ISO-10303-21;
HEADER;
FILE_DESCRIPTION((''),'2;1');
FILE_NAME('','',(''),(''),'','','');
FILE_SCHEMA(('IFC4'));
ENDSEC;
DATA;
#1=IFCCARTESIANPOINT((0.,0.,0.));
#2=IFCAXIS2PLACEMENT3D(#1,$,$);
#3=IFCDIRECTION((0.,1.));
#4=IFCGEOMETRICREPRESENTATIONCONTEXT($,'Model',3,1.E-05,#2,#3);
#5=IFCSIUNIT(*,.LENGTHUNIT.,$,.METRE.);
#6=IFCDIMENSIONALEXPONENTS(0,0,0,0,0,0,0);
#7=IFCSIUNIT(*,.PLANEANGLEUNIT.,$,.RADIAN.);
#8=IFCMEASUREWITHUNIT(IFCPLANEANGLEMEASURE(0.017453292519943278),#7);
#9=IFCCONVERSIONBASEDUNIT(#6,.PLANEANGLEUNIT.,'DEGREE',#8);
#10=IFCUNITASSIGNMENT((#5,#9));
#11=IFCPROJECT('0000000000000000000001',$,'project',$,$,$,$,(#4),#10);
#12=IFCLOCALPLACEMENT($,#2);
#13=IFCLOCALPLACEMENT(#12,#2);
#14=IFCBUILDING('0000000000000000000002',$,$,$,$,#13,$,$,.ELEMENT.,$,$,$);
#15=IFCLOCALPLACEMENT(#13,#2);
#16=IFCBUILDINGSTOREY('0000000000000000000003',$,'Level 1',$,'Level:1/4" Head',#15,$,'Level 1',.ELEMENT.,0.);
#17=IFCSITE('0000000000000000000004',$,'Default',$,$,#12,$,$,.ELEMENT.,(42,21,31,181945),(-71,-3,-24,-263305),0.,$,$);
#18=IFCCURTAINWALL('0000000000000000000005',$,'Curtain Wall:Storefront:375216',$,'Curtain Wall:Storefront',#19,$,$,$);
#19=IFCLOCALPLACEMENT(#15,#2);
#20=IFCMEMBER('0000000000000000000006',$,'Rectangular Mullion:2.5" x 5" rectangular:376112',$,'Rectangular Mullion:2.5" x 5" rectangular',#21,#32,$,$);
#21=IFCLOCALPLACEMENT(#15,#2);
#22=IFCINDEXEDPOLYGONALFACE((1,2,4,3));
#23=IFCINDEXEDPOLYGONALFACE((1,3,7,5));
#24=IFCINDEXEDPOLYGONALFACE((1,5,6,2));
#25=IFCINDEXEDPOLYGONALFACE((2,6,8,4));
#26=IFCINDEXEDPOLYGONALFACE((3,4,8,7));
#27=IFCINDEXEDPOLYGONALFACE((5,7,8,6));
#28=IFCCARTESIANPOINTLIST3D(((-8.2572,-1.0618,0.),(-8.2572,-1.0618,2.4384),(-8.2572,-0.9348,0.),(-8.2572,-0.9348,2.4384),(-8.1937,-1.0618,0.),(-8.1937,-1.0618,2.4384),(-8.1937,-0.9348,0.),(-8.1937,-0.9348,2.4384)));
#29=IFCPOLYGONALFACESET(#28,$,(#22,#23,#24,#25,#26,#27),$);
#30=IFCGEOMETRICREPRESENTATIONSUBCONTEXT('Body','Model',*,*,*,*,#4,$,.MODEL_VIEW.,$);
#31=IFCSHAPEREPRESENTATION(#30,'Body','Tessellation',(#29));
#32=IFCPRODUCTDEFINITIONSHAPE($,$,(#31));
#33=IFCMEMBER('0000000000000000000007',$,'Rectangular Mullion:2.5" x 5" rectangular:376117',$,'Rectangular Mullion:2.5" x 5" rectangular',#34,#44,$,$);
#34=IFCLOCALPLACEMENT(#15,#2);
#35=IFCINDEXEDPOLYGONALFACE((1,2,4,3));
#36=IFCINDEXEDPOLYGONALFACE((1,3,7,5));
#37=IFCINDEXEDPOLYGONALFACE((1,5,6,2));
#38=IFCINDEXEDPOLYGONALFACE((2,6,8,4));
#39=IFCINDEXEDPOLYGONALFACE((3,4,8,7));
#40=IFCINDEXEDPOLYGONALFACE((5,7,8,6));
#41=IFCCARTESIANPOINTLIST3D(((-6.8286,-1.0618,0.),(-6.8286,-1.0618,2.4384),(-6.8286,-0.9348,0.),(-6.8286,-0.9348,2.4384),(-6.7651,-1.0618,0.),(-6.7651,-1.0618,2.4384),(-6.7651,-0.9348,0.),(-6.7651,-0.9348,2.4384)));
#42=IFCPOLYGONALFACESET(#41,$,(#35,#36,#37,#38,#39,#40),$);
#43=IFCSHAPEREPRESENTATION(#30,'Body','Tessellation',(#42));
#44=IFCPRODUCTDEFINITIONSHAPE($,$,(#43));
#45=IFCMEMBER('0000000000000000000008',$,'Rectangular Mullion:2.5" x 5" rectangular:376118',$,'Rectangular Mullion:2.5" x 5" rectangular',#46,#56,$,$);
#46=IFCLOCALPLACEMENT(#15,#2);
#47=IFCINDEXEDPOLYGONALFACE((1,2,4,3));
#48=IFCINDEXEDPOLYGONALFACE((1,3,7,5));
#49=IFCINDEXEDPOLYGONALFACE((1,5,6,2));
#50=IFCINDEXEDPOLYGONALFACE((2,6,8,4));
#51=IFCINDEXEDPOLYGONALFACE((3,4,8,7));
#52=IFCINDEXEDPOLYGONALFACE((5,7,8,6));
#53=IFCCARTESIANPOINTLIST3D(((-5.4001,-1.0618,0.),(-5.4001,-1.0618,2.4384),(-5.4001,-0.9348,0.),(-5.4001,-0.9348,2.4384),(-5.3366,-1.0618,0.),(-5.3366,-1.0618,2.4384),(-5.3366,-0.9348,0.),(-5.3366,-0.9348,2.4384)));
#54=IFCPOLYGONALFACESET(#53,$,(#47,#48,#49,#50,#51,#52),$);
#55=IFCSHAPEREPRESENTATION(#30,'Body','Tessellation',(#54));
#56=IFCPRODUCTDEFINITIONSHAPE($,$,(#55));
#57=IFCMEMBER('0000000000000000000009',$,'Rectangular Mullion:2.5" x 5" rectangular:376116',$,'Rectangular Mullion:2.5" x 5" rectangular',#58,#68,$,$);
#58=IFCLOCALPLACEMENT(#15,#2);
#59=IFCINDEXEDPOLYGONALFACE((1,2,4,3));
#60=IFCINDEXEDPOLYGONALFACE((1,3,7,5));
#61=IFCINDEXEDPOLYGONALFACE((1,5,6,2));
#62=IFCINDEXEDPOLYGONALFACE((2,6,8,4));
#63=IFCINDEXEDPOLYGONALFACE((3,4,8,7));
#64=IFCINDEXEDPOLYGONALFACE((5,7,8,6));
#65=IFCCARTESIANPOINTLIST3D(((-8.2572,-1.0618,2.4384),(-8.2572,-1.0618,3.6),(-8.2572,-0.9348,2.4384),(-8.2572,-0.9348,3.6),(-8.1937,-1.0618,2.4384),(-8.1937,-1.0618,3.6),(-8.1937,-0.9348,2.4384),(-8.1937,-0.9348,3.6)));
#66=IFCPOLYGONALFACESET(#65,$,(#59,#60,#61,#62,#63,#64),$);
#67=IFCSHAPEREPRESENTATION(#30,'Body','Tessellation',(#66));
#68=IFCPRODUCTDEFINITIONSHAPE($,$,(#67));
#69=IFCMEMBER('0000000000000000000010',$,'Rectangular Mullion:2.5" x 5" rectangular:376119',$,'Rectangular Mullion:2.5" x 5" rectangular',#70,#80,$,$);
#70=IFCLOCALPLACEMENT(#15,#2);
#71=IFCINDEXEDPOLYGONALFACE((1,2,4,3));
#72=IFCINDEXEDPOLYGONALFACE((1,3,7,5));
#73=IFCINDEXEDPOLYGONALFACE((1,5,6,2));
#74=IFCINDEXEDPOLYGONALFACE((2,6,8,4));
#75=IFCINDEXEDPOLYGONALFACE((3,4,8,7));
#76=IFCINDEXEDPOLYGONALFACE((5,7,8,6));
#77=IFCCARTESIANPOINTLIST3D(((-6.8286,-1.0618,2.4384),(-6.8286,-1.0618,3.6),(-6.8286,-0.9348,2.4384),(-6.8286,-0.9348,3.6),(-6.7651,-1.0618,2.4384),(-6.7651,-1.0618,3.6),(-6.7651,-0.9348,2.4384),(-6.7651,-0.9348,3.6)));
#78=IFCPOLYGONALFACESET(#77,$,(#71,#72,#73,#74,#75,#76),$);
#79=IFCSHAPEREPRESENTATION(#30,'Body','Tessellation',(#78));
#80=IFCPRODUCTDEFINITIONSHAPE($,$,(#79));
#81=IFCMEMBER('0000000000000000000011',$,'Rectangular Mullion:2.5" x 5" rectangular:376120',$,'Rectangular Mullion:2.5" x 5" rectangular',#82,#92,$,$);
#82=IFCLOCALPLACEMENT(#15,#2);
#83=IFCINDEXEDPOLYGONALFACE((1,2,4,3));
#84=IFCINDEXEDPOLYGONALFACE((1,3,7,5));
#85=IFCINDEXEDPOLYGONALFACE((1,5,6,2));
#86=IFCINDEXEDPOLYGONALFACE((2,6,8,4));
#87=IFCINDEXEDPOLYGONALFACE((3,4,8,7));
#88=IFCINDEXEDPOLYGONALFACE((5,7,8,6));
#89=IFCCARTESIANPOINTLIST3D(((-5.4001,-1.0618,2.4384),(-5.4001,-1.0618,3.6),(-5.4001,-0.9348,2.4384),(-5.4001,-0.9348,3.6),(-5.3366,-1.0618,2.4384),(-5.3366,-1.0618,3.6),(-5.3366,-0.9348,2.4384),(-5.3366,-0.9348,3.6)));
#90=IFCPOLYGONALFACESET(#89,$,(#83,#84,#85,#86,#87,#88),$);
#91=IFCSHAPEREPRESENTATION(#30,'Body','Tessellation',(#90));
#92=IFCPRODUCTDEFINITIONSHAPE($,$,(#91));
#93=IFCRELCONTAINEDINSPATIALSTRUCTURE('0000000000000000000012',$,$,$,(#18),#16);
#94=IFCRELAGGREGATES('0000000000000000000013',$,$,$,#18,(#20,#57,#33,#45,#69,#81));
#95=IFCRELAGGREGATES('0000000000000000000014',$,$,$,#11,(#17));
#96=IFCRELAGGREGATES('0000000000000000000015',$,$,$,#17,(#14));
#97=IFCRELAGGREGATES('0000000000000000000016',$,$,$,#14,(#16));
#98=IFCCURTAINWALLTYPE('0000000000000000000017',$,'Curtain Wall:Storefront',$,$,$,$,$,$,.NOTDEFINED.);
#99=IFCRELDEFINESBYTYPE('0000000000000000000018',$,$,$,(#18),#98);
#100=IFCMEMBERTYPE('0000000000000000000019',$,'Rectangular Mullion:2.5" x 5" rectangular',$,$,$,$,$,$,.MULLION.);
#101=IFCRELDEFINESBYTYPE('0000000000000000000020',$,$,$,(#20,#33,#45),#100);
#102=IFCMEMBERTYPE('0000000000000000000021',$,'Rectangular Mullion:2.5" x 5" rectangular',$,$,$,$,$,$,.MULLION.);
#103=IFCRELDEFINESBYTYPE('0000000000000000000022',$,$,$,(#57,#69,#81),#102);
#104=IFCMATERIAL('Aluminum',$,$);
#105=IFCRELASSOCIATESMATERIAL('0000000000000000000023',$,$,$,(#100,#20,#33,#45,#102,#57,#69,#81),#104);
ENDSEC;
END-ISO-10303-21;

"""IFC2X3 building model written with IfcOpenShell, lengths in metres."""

from ifc_helpers import new_model, entity, si_unit, converted_unit, direction, frame, origin, origin_2d_with_axis, place, context, subcontext, project, spatial, rectangle, extrude, source, transform, mapped, material, type_object, type_shapes, element, aggregate, save


model = new_model("IFC2X3")

# Units and contexts
model_context = context("Model", 3, precision=1e-05, world=origin(), true_north=direction((0.0, 1.0)))
body_context = subcontext(model_context, "Body", "Model", "MODEL_VIEW")
ifc_project = project(units=[si_unit("LENGTHUNIT", "METRE"), converted_unit("PLANEANGLEUNIT", "DEGREE", entity("IfcPlaneAngleMeasure", 0.017453292519943278), si_unit("PLANEANGLEUNIT", "RADIAN"), dimensions=[0, 0, 0, 0, 0, 0, 0])], contexts=[model_context])

# Site, building, storey
site_placement = place(None, origin())
site = spatial("IfcSite", under=ifc_project, at=site_placement, Name="Default", CompositionType="ELEMENT", RefLatitude=(42, 21, 31, 181945), RefLongitude=(-71, -3, -24, -263305), RefElevation=0.0)
building_placement = place(site_placement, origin())
building = spatial("IfcBuilding", under=site, at=building_placement, CompositionType="ELEMENT")
storey_placement = place(building_placement, origin())
storey = spatial("IfcBuildingStorey", under=building, at=storey_placement, Name="Level 1", ObjectType="Level:1/4\" Head", LongName="Level 1", CompositionType="ELEMENT", Elevation=0.0)

# Curtain wall, members
curtain_wall_type = type_object("IfcCurtainWallType", Name="Curtain Wall:Storefront", PredefinedType="NOTDEFINED")
curtain_wall_placement = place(storey_placement, origin())
curtain_wall = element("IfcCurtainWall", 1, at=curtain_wall_placement, inside=storey, type_object=curtain_wall_type, Name="Curtain Wall:Storefront:375216", ObjectType="Curtain Wall:Storefront")
ifc_material_1 = material(Name="Aluminum")
member_type_1 = type_object("IfcMemberType", Name="Rectangular Mullion:2.5\" x 5\" rectangular", PredefinedType="MULLION", material=ifc_material_1)
shared_shape_1 = source(origin(), body_context, "Body", "SweptSolid", [
    extrude(rectangle(XDim=0.0635, YDim=0.127, at=origin_2d_with_axis()), frame((0.0, 0.0, -2.4384), z_axis=(0.0, 0.0, 1.0), x_axis=(-1.0, 0.0, 0.0)), (0.0, 0.0, 1.0), 2.4384),
])
type_shapes(member_type_1, [shared_shape_1])
member_1_placement = place(curtain_wall_placement, frame((-8.2254, -0.9983, 0.0), z_axis=(0.0, 0.0, -1.0), x_axis=(1.0, 0.0, 0.0)))
member_1 = element("IfcMember", 2, at=member_1_placement, type_object=member_type_1, material=ifc_material_1, Name="Rectangular Mullion:2.5\" x 5\" rectangular:376112", ObjectType="Rectangular Mullion:2.5\" x 5\" rectangular", context=body_context, shape_type="MappedRepresentation", body=[
    mapped(shared_shape_1, transform((0.0, 0.0, 0.0), scale=1.0)),
])
member_2_placement = place(curtain_wall_placement, frame((-6.7969, -0.9983, 0.0), z_axis=(0.0, 0.0, -1.0), x_axis=(1.0, 0.0, 0.0)))
member_2 = element("IfcMember", 3, at=member_2_placement, type_object=member_type_1, material=ifc_material_1, Name="Rectangular Mullion:2.5\" x 5\" rectangular:376117", ObjectType="Rectangular Mullion:2.5\" x 5\" rectangular", context=body_context, shape_type="MappedRepresentation", body=[
    mapped(shared_shape_1, transform((0.0, 0.0, 0.0), scale=1.0)),
])
member_3_placement = place(curtain_wall_placement, frame((-5.3683, -0.9983, 0.0), z_axis=(0.0, 0.0, -1.0), x_axis=(1.0, 0.0, 0.0)))
member_3 = element("IfcMember", 4, at=member_3_placement, type_object=member_type_1, material=ifc_material_1, Name="Rectangular Mullion:2.5\" x 5\" rectangular:376118", ObjectType="Rectangular Mullion:2.5\" x 5\" rectangular", context=body_context, shape_type="MappedRepresentation", body=[
    mapped(shared_shape_1, transform((0.0, 0.0, 0.0), scale=1.0)),
])
member_type_2 = type_object("IfcMemberType", Name="Rectangular Mullion:2.5\" x 5\" rectangular", PredefinedType="MULLION", material=ifc_material_1)
shared_shape_2 = source(origin(), body_context, "Body", "SweptSolid", [
    extrude(rectangle(XDim=0.0635, YDim=0.127, at=origin_2d_with_axis()), frame((0.0, 0.0, -1.1616), z_axis=(0.0, 0.0, 1.0), x_axis=(-1.0, 0.0, 0.0)), (0.0, 0.0, 1.0), 1.1616),
])
type_shapes(member_type_2, [shared_shape_2])
member_4_placement = place(curtain_wall_placement, frame((-8.2254, -0.9983, 2.4384), z_axis=(0.0, 0.0, -1.0), x_axis=(1.0, 0.0, 0.0)))
member_4 = element("IfcMember", 5, at=member_4_placement, type_object=member_type_2, material=ifc_material_1, Name="Rectangular Mullion:2.5\" x 5\" rectangular:376116", ObjectType="Rectangular Mullion:2.5\" x 5\" rectangular", context=body_context, shape_type="MappedRepresentation", body=[
    mapped(shared_shape_2, transform((0.0, 0.0, 0.0), scale=1.0)),
])
member_5_placement = place(curtain_wall_placement, frame((-6.7969, -0.9983, 2.4384), z_axis=(0.0, 0.0, -1.0), x_axis=(1.0, 0.0, 0.0)))
member_5 = element("IfcMember", 6, at=member_5_placement, type_object=member_type_2, material=ifc_material_1, Name="Rectangular Mullion:2.5\" x 5\" rectangular:376119", ObjectType="Rectangular Mullion:2.5\" x 5\" rectangular", context=body_context, shape_type="MappedRepresentation", body=[
    mapped(shared_shape_2, transform((0.0, 0.0, 0.0), scale=1.0)),
])
member_6_placement = place(curtain_wall_placement, frame((-5.3683, -0.9983, 2.4384), z_axis=(0.0, 0.0, -1.0), x_axis=(1.0, 0.0, 0.0)))
member_6 = element("IfcMember", 7, at=member_6_placement, type_object=member_type_2, material=ifc_material_1, Name="Rectangular Mullion:2.5\" x 5\" rectangular:376120", ObjectType="Rectangular Mullion:2.5\" x 5\" rectangular", context=body_context, shape_type="MappedRepresentation", body=[
    mapped(shared_shape_2, transform((0.0, 0.0, 0.0), scale=1.0)),
])
aggregate(curtain_wall, [member_1, member_4, member_2, member_3, member_5, member_6])

save(model, "model.ifc")
